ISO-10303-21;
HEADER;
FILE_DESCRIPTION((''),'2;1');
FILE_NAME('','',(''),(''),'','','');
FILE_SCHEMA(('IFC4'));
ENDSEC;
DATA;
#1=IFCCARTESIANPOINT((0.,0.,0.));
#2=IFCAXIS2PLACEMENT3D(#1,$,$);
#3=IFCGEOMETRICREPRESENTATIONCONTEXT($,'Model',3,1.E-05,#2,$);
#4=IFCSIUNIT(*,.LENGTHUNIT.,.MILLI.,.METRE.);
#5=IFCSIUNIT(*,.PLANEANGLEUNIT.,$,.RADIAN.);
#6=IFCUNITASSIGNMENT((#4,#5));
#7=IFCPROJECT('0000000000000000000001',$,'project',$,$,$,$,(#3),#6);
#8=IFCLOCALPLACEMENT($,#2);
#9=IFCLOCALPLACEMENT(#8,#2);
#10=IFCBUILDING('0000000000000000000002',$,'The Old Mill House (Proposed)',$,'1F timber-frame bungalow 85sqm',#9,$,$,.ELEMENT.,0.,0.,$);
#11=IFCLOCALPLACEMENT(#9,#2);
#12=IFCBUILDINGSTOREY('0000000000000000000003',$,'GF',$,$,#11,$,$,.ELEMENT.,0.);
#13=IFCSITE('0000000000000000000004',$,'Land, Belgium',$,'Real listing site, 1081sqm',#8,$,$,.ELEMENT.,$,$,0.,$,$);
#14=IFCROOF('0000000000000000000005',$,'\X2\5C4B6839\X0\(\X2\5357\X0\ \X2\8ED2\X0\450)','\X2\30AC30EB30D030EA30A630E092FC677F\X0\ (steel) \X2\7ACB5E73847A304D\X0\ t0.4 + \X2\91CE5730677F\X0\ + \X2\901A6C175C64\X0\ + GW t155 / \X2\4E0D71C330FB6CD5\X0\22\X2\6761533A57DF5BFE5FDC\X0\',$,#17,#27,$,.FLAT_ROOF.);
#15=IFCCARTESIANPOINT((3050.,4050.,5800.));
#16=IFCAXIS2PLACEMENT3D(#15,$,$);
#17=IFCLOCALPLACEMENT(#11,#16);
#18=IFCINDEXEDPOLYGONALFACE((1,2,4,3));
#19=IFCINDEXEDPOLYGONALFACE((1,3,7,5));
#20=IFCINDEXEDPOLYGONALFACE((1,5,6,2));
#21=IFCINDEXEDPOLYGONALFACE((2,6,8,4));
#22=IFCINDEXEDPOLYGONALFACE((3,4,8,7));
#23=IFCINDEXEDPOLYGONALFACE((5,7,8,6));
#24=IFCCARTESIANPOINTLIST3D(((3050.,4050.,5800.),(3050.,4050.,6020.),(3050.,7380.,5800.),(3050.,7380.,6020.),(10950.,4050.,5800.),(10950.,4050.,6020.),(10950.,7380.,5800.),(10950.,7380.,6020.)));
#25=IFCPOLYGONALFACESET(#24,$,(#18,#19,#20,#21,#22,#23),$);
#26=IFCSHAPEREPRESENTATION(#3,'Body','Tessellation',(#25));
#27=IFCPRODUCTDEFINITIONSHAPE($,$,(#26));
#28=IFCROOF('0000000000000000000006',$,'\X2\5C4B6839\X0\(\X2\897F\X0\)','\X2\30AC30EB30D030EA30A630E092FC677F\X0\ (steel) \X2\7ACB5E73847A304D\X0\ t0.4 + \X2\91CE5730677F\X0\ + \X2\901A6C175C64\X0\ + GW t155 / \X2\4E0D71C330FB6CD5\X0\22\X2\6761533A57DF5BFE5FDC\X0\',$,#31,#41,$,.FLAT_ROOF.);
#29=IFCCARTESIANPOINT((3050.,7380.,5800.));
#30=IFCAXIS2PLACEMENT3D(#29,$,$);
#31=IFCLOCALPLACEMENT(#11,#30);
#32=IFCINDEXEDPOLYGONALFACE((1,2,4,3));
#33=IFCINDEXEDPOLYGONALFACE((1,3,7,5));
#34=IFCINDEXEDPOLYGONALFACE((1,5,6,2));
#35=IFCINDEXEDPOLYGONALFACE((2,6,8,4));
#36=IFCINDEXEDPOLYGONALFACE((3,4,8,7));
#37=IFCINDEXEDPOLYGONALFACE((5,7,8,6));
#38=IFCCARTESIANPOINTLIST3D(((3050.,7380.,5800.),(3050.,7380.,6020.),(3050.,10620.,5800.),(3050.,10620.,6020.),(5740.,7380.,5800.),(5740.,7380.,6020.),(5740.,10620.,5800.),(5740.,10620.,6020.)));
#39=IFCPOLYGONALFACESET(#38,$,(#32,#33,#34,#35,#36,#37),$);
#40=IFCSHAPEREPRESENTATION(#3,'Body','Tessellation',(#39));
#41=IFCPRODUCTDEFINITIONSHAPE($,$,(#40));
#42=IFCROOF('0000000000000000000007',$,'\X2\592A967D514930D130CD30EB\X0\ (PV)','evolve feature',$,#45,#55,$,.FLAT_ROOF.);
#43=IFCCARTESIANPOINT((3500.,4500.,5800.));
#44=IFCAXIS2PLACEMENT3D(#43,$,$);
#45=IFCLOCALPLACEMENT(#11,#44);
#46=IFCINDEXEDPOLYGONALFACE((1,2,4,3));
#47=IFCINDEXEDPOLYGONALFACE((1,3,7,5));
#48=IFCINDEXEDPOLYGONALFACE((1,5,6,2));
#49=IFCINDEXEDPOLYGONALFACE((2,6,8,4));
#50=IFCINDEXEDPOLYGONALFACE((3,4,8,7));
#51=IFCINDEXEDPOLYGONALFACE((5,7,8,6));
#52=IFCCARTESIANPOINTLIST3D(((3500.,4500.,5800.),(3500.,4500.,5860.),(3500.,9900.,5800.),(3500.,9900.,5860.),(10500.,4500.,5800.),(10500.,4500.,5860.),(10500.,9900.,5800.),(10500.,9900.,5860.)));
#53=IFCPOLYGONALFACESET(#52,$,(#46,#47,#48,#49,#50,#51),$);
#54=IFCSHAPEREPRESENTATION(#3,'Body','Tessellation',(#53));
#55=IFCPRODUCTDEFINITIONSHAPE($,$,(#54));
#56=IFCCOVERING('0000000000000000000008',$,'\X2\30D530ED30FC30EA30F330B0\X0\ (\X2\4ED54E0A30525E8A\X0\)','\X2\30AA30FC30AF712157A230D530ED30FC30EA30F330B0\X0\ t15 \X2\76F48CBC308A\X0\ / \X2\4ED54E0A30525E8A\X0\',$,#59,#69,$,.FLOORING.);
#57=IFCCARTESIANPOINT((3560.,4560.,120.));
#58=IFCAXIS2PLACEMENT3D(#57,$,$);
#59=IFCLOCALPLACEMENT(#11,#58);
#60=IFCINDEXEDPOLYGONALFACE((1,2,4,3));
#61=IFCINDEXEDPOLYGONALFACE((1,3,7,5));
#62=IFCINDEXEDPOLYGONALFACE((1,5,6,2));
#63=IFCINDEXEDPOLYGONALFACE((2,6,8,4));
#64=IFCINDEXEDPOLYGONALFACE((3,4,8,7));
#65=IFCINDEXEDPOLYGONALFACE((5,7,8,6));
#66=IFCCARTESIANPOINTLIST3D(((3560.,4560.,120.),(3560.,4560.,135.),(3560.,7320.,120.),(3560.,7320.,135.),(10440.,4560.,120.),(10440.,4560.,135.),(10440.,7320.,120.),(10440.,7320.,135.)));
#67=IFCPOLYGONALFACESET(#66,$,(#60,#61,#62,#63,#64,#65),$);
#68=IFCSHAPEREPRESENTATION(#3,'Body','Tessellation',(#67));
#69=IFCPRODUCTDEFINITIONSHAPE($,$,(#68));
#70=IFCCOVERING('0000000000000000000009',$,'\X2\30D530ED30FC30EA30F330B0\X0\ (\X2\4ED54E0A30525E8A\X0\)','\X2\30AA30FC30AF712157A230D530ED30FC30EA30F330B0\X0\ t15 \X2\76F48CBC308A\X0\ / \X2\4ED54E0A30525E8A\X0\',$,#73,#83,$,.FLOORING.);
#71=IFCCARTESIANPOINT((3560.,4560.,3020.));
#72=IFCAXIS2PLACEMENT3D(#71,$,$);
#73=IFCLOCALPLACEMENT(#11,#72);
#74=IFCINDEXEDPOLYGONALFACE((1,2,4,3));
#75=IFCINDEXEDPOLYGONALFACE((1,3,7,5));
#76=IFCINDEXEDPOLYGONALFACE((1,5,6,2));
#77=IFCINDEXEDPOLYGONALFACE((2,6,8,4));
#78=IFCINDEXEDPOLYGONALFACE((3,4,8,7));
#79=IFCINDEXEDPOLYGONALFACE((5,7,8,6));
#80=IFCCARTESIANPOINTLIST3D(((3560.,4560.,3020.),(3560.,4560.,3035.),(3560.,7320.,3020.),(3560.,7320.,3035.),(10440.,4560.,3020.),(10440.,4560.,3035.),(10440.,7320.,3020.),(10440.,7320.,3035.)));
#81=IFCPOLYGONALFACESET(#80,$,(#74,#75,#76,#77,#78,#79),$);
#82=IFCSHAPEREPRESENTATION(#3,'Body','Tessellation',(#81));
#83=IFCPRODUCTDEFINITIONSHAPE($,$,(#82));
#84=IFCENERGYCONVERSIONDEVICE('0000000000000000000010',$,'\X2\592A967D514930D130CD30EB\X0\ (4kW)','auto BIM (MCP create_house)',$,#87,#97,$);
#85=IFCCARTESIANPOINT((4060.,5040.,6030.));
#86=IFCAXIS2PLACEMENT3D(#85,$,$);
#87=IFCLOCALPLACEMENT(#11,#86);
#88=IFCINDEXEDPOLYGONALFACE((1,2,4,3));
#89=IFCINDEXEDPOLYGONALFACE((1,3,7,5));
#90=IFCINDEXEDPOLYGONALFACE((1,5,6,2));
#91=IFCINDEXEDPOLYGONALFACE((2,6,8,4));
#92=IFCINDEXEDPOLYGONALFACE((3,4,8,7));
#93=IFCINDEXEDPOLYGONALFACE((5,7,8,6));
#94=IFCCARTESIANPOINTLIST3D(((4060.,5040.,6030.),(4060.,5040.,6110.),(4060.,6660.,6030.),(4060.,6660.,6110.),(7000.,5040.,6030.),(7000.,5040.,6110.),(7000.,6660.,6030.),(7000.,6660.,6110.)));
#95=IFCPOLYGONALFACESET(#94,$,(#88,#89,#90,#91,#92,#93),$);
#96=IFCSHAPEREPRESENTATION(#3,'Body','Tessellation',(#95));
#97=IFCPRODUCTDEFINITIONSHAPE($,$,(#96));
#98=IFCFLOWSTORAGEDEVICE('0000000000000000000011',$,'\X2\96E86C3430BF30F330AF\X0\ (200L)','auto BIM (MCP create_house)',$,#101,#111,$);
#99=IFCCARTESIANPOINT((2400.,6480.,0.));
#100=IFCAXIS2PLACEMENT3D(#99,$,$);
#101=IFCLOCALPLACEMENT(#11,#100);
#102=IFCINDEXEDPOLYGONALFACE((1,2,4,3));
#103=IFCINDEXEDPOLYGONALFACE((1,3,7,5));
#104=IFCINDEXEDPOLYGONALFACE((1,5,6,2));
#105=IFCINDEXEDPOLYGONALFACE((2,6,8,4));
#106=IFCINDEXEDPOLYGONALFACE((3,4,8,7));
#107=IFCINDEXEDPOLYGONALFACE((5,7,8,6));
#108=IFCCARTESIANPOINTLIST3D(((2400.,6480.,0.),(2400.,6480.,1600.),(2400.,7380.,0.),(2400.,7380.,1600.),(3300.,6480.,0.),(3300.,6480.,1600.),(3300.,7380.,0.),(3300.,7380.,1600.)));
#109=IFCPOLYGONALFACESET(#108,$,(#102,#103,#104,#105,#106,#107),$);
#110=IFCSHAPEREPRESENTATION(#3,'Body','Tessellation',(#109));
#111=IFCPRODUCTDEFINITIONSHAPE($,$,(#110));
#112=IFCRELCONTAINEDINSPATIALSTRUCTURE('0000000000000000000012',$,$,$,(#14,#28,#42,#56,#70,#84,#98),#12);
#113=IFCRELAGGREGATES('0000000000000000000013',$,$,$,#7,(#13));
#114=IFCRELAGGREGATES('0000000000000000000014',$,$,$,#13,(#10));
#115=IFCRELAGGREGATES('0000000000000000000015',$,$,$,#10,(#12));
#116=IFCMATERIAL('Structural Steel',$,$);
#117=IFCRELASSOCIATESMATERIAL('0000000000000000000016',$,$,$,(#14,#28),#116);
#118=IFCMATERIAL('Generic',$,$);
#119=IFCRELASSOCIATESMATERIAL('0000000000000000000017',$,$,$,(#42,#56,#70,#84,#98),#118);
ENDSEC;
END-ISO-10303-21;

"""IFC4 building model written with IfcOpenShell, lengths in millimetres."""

from ifc_helpers import new_model, si_unit, frame, frame_2d, origin, place, context, project, spatial, rectangle, extrude, material, element, save


model = new_model("IFC4")

# Units and contexts
model_context = context("Model", 3, precision=1e-05, world=origin())
ifc_project = project(units=[si_unit("LENGTHUNIT", "METRE", prefix="MILLI"), si_unit("PLANEANGLEUNIT", "RADIAN")], contexts=[model_context])

# Site, building, storey
site_placement = place(None, origin())
site = spatial("IfcSite", under=ifc_project, at=site_placement, Name="Land, Belgium", ObjectType="Real listing site, 1081sqm", CompositionType="ELEMENT", RefElevation=0.0)
building_placement = place(site_placement, origin())
building = spatial("IfcBuilding", under=site, at=building_placement, Name="The Old Mill House (Proposed)", ObjectType="1F timber-frame bungalow 85sqm", CompositionType="ELEMENT", ElevationOfRefHeight=0.0, ElevationOfTerrain=0.0)
storey_placement = place(building_placement, origin())
storey = spatial("IfcBuildingStorey", under=building, at=storey_placement, Name="GF", CompositionType="ELEMENT", Elevation=0.0)

# Shared definitions
ifc_material_1 = material(Name="Generic")

# Roofs
ifc_material_2 = material(Name="Structural Steel")
roof_1_placement = place(storey_placement, frame((3050.0, 4050.0, 5800.0)))
element("IfcRoof", 1, at=roof_1_placement, inside=storey, material=ifc_material_2, Name="屋根(南 軒450)", Description="ガルバリウム鋼板 (steel) 立平葺き t0.4 + 野地板 + 通気層 + GW t155 / 不燃・法22条区域対応", PredefinedType="FLAT_ROOF", context=model_context, shape_type="SweptSolid", body=[
    extrude(rectangle(XDim=7900.0, YDim=3330.0, at=frame_2d((3950.0, 1665.0))), frame((3050.0, 4050.0, 5800.0)), (0.0, 0.0, 1.0), 220.0),
])
roof_2_placement = place(storey_placement, frame((3050.0, 7380.0, 5800.0)))
element("IfcRoof", 2, at=roof_2_placement, inside=storey, material=ifc_material_2, Name="屋根(西)", Description="ガルバリウム鋼板 (steel) 立平葺き t0.4 + 野地板 + 通気層 + GW t155 / 不燃・法22条区域対応", PredefinedType="FLAT_ROOF", context=model_context, shape_type="SweptSolid", body=[
    extrude(rectangle(XDim=2690.0, YDim=3240.0, at=frame_2d((1345.0, 1620.0))), frame((3050.0, 7380.0, 5800.0)), (0.0, 0.0, 1.0), 220.0),
])
roof_3_placement = place(storey_placement, frame((3500.0, 4500.0, 5800.0)))
element("IfcRoof", 3, at=roof_3_placement, inside=storey, material=ifc_material_1, Name="太陽光パネル (PV)", Description="evolve feature", PredefinedType="FLAT_ROOF", context=model_context, shape_type="SweptSolid", body=[
    extrude(rectangle(XDim=7000.0, YDim=5400.0, at=frame_2d((3500.0, 2700.0))), frame((3500.0, 4500.0, 5800.0)), (0.0, 0.0, 1.0), 60.0),
])

# Coverings
covering_1_placement = place(storey_placement, frame((3560.0, 4560.0, 120.0)))
element("IfcCovering", 4, at=covering_1_placement, inside=storey, material=ifc_material_1, Name="フローリング (仕上げ床)", Description="オーク無垢フローリング t15 直貼り / 仕上げ床", PredefinedType="FLOORING", context=model_context, shape_type="SweptSolid", body=[
    extrude(rectangle(XDim=6880.0, YDim=2760.0, at=frame_2d((3440.0, 1380.0))), frame((3560.0, 4560.0, 120.0)), (0.0, 0.0, 1.0), 15.0),
])
covering_2_placement = place(storey_placement, frame((3560.0, 4560.0, 3020.0)))
element("IfcCovering", 5, at=covering_2_placement, inside=storey, material=ifc_material_1, Name="フローリング (仕上げ床)", Description="オーク無垢フローリング t15 直貼り / 仕上げ床", PredefinedType="FLOORING", context=model_context, shape_type="SweptSolid", body=[
    extrude(rectangle(XDim=6880.0, YDim=2760.0, at=frame_2d((3440.0, 1380.0))), frame((3560.0, 4560.0, 3020.0)), (0.0, 0.0, 1.0), 15.0),
])

# Energy conversion device
energy_conversion_device_placement = place(storey_placement, frame((4060.0, 5040.0, 6030.0)))
element("IfcEnergyConversionDevice", 6, at=energy_conversion_device_placement, inside=storey, material=ifc_material_1, Name="太陽光パネル (4kW)", Description="auto BIM (MCP create_house)", context=model_context, shape_type="SweptSolid", body=[
    extrude(rectangle(XDim=2940.0, YDim=1620.0, at=frame_2d((1470.0, 810.0))), frame((4060.0, 5040.0, 6030.0)), (0.0, 0.0, 1.0), 80.0),
])

# Flow storage device
flow_storage_device_placement = place(storey_placement, frame((2400.0, 6480.0, 0.0)))
element("IfcFlowStorageDevice", 7, at=flow_storage_device_placement, inside=storey, material=ifc_material_1, Name="雨水タンク (200L)", Description="auto BIM (MCP create_house)", context=model_context, shape_type="SweptSolid", body=[
    extrude(rectangle(XDim=900.0, YDim=900.0, at=frame_2d((450.0, 450.0))), frame((2400.0, 6480.0, 0.0)), (0.0, 0.0, 1.0), 1600.0),
])

save(model, "model.ifc")
